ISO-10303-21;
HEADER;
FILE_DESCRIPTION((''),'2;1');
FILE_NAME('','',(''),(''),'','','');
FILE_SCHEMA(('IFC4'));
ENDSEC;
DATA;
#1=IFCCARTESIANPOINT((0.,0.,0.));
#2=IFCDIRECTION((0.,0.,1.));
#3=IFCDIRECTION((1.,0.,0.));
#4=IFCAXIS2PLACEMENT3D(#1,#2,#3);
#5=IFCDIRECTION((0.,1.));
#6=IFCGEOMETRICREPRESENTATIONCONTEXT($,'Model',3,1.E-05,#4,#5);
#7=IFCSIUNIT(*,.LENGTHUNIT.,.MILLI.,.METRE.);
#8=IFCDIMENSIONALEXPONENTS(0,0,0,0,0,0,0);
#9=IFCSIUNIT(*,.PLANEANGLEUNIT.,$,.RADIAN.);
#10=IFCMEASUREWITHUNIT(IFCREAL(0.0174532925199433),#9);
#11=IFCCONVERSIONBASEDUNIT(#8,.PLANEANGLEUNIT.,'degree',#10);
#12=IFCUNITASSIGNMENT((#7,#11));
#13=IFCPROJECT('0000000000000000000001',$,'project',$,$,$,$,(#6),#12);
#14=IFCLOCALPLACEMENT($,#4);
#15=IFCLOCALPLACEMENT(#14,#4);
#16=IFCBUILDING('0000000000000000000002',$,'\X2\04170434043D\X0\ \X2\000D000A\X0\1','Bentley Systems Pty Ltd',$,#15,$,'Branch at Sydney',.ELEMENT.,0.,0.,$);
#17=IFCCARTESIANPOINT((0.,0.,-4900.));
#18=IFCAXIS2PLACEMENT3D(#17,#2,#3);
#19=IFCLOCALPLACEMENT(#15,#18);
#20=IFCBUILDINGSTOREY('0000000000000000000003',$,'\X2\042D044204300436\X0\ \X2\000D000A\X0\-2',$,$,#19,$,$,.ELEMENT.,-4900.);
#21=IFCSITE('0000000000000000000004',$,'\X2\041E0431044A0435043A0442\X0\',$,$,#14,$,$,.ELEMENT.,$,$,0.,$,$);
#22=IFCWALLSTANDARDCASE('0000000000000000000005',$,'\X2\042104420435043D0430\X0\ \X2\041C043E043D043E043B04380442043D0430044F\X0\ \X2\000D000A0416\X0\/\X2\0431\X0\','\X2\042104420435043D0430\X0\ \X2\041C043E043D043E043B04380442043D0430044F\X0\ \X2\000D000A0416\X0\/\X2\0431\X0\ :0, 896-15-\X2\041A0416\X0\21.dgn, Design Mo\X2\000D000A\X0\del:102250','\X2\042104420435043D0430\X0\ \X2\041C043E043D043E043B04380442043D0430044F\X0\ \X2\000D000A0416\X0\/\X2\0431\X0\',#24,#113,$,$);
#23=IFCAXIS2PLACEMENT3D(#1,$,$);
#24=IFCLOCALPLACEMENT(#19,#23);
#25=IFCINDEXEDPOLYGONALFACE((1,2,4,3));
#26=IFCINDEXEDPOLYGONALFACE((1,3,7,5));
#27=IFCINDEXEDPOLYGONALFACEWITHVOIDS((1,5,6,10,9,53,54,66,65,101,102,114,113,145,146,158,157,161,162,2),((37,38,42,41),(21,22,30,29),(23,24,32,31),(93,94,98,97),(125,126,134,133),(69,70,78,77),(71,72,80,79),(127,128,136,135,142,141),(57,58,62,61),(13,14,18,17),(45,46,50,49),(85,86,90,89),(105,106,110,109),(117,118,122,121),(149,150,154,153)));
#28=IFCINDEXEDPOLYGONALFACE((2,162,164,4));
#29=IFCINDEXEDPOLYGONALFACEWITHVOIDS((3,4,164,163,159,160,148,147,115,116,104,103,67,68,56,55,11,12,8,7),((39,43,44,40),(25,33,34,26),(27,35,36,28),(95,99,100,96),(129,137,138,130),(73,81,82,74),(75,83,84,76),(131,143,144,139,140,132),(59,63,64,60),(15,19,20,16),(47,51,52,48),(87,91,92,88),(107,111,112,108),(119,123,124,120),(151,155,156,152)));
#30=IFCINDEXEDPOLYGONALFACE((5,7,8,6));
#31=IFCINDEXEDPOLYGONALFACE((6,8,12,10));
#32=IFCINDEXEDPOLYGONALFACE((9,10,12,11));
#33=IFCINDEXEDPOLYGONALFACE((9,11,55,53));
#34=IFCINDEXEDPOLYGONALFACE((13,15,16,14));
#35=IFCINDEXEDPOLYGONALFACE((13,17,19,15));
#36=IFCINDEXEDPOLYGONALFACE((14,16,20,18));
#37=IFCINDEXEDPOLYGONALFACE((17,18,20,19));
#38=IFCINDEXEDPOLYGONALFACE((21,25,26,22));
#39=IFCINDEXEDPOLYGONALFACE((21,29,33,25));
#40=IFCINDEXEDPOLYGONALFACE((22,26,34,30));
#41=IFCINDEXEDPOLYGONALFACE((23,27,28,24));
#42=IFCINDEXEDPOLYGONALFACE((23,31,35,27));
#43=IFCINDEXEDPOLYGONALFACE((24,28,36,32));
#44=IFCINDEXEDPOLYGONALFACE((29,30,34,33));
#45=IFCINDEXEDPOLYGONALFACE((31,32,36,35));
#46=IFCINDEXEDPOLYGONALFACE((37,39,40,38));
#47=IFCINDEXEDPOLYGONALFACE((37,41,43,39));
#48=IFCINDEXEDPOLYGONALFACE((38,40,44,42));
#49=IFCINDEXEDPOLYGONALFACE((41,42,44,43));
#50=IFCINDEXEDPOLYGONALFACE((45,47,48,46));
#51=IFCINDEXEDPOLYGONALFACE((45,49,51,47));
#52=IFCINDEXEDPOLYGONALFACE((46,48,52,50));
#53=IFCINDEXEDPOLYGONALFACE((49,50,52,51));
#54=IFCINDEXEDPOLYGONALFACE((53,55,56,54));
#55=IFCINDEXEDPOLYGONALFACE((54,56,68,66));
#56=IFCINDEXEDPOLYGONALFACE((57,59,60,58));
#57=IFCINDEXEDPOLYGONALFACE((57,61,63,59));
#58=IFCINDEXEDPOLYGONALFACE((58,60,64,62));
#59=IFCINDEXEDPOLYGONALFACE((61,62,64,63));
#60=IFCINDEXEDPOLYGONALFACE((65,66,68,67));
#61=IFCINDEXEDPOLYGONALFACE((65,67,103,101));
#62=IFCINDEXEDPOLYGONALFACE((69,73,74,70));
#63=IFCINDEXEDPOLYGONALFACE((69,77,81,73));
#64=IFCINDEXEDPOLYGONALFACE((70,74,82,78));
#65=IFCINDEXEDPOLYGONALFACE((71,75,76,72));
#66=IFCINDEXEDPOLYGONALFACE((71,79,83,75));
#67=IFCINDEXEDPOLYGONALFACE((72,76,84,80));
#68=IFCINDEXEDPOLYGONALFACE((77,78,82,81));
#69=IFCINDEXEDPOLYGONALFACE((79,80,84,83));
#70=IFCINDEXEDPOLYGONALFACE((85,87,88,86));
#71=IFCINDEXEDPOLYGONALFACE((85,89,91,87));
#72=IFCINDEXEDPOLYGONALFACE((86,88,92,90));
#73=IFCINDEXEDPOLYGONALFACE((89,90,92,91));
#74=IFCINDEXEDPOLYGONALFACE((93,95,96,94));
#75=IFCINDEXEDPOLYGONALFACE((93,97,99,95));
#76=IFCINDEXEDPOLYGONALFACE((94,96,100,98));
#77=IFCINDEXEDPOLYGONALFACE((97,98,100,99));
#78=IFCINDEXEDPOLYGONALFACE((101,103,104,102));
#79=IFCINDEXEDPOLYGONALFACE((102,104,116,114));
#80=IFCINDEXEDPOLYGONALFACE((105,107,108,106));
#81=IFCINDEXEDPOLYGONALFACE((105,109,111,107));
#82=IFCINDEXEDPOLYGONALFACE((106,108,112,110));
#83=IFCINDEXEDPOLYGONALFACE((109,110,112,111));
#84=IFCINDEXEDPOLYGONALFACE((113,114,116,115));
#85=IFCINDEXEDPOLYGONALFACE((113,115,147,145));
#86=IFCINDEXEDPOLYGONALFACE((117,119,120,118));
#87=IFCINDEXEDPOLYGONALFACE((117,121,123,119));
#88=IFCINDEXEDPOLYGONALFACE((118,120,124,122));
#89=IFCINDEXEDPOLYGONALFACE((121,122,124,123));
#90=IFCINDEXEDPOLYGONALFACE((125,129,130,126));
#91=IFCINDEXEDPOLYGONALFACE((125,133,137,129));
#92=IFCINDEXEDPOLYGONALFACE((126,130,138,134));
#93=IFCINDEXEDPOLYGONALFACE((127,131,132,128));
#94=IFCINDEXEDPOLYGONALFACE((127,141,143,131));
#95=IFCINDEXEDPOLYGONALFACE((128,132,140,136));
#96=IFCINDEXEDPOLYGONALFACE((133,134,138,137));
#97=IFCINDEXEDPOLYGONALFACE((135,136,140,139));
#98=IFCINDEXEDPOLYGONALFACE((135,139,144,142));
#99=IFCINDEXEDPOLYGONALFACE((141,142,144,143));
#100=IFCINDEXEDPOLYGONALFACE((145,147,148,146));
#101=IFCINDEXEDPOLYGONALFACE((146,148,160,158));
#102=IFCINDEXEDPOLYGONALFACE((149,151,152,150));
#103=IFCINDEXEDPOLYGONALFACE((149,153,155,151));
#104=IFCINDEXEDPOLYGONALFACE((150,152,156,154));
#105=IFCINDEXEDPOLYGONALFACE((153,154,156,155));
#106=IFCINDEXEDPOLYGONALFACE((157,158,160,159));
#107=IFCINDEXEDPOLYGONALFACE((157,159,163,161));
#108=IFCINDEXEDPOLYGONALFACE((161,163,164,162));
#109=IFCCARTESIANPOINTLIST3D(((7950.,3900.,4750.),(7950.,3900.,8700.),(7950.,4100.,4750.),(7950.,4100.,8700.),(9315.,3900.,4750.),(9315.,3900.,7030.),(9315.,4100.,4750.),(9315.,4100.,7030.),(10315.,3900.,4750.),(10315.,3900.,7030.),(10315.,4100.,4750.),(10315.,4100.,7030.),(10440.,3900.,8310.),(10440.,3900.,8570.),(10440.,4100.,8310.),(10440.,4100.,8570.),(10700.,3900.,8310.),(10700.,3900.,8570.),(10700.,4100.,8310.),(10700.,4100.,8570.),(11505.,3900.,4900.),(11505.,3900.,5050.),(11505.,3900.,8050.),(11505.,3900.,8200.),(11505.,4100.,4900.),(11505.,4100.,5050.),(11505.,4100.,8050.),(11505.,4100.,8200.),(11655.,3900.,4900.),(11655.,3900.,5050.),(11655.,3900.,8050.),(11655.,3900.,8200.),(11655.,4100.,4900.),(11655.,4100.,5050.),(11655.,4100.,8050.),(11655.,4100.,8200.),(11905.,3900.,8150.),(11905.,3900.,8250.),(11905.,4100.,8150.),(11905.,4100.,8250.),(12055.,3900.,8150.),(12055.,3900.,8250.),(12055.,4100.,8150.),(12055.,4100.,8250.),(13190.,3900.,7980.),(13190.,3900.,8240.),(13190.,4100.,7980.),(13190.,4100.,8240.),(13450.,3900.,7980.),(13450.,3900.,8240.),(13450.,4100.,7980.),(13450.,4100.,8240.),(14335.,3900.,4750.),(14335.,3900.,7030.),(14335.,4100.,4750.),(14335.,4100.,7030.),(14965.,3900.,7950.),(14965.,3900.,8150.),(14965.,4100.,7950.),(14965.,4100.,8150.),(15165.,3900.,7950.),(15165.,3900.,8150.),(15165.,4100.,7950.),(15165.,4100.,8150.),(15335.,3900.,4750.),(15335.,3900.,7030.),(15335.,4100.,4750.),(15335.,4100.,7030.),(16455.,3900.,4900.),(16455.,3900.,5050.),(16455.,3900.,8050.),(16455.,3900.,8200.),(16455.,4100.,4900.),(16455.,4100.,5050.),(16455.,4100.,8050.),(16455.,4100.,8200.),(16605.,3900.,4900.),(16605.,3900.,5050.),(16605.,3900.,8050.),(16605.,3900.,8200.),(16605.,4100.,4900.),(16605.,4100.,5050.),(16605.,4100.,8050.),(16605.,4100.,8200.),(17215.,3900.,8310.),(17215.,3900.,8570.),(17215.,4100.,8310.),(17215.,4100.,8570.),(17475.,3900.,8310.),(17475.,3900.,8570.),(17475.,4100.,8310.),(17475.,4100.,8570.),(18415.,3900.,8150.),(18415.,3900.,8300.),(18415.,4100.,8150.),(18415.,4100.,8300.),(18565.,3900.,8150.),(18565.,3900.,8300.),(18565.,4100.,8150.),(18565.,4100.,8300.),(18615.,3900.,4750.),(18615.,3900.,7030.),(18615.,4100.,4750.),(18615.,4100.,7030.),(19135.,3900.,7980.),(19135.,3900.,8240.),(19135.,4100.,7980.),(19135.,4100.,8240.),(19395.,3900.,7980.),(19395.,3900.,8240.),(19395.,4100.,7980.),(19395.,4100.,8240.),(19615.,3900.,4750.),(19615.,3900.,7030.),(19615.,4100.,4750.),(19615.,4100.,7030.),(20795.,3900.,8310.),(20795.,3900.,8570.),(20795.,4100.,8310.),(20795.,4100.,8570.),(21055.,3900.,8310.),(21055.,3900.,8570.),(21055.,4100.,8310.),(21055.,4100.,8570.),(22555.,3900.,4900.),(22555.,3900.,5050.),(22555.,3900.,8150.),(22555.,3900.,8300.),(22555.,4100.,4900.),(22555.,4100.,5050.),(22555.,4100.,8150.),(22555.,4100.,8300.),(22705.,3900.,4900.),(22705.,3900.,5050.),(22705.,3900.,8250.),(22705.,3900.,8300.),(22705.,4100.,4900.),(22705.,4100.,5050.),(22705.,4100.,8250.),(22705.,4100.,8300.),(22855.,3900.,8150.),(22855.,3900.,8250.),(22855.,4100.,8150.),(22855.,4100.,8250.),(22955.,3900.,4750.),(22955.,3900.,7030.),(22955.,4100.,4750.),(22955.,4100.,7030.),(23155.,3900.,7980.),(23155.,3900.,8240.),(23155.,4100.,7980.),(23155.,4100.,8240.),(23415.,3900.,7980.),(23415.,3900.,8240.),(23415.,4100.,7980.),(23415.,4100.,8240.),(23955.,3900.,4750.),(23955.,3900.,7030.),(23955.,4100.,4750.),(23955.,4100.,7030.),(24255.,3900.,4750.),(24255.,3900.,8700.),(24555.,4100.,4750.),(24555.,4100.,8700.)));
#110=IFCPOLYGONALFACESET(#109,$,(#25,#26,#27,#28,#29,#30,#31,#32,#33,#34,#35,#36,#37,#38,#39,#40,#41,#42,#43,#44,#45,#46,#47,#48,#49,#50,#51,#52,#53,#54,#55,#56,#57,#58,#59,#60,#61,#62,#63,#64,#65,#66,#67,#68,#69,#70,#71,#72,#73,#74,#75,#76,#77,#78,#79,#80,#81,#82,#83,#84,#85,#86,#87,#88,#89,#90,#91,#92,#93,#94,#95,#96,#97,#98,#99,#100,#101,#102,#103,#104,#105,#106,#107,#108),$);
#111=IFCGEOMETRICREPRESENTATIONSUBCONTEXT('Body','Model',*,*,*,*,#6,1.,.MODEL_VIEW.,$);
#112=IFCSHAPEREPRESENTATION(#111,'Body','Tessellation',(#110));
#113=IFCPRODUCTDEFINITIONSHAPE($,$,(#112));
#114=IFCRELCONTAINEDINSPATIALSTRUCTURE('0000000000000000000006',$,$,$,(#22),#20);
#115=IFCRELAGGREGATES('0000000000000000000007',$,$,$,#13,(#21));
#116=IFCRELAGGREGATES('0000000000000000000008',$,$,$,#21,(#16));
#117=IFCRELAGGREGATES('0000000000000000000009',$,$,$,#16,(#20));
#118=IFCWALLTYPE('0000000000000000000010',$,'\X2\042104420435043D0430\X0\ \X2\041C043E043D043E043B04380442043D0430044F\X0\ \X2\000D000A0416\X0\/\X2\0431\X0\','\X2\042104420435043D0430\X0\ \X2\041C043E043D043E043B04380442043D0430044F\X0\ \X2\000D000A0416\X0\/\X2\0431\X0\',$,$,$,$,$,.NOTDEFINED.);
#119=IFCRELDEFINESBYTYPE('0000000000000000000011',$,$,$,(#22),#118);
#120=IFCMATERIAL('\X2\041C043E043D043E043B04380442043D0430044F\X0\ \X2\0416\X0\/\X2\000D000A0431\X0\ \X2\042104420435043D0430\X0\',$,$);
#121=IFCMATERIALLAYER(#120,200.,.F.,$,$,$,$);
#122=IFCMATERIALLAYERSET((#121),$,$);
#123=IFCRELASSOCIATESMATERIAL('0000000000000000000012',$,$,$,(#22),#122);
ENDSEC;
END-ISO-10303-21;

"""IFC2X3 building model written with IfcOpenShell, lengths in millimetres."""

from ifc_helpers import new_model, entity, si_unit, converted_unit, direction, frame, frame_2d, origin_with_axes, place, context, subcontext, project, spatial, polyline, rectangle, outline, extrude, material, layer, layer_set, layer_usage, type_object, element, save


model = new_model("IFC2X3")

# Units and contexts
model_context = context("Model", 3, precision=1e-05, world=origin_with_axes(), true_north=direction((0.0, 1.0)))
body_context = subcontext(model_context, "Body", "Model", "MODEL_VIEW", scale=1.0)
ifc_project = project(units=[si_unit("LENGTHUNIT", "METRE", prefix="MILLI"), converted_unit("PLANEANGLEUNIT", "degree", entity("IfcReal", 0.0174532925199433), si_unit("PLANEANGLEUNIT", "RADIAN"), dimensions=[0, 0, 0, 0, 0, 0, 0])], contexts=[model_context])

# Site, building, storey
site_placement = place(None, origin_with_axes())
site = spatial("IfcSite", under=ifc_project, at=site_placement, Name="Объект", CompositionType="ELEMENT", RefElevation=0.0)
building_placement = place(site_placement, origin_with_axes())
building = spatial("IfcBuilding", under=site, at=building_placement, Name="Здн \r\n1", Description="Bentley Systems Pty Ltd", LongName="Branch at Sydney", CompositionType="ELEMENT", ElevationOfRefHeight=0.0, ElevationOfTerrain=0.0)
storey_placement = place(building_placement, frame((0.0, 0.0, -4900.0), z_axis=(0.0, 0.0, 1.0), x_axis=(1.0, 0.0, 0.0)))
storey = spatial("IfcBuildingStorey", under=building, at=storey_placement, Name="Этаж \r\n-2", CompositionType="ELEMENT", Elevation=-4900.0)

# Wall, openings
ifc_material = material(Name="Монолитная Ж/\r\nб Стена")
wall_type = type_object("IfcWallType", Name="Стена Монолитная \r\nЖ/б", Description="Стена Монолитная \r\nЖ/б", PredefinedType="NOTDEFINED")
ifc_layer_1 = layer(ifc_material, 200.0, ventilated=False)
ifc_layer_set_1 = layer_set([ifc_layer_1])
ifc_layer_usage_1 = layer_usage(ifc_layer_set_1, "AXIS2", "POSITIVE", 0.0)
wall_1_placement = place(storey_placement, frame((7950.0, 3900.0, 4750.0), z_axis=(0.0, 0.0, 1.0), x_axis=(1.0, 0.0, 0.0)))
wall_1 = element("IfcWallStandardCase", 1, at=wall_1_placement, inside=storey, type_object=wall_type, material=ifc_layer_usage_1, Name="Стена Монолитная \r\nЖ/б", Description="Стена Монолитная \r\nЖ/б :0, 896-15-КЖ21.dgn, Design Mo\r\ndel:102250", ObjectType="Стена Монолитная \r\nЖ/б", context=body_context, shape_type="SweptSolid", body=[
    extrude(outline(polyline([(16605.0, 200.0), (0.0, 200.0), (0.0, 0.0), (16305.0, 0.0), (16605.0, 200.0)])), origin_with_axes(), (0.0, 0.0, 1.0), 3950.0),
])
opening_1_placement = place(wall_1_placement, frame((1365.0, 0.0, 0.0), z_axis=(0.0, 0.0, 1.0), x_axis=(1.0, 0.0, 0.0)))
element("IfcOpeningElement", 2, at=opening_1_placement, cuts=wall_1, ObjectType="Opening", context=body_context, shape_type="SweptSolid", body=[
    extrude(rectangle(XDim=2280.0, YDim=1000.0, at=frame_2d((-500.0, 1140.0), x_axis=(0.0, -1.0))), frame((0.0, 0.0, 0.0), z_axis=(0.0, 1.0, 0.0), x_axis=(-1.0, 0.0, 0.0)), (0.0, 0.0, 1.0), 200.0),
])
opening_2_placement = place(wall_1_placement, frame((6385.0, 0.0, 0.0), z_axis=(0.0, 0.0, 1.0), x_axis=(1.0, 0.0, 0.0)))
element("IfcOpeningElement", 3, at=opening_2_placement, cuts=wall_1, ObjectType="Opening", context=body_context, shape_type="SweptSolid", body=[
    extrude(rectangle(XDim=2280.0, YDim=1000.0, at=frame_2d((-500.0, 1140.0), x_axis=(0.0, -1.0))), frame((0.0, 0.0, 0.0), z_axis=(0.0, 1.0, 0.0), x_axis=(-1.0, 0.0, 0.0)), (0.0, 0.0, 1.0), 200.0),
])
opening_3_placement = place(wall_1_placement, frame((10665.0, 0.0, 0.0), z_axis=(0.0, 0.0, 1.0), x_axis=(1.0, 0.0, 0.0)))
element("IfcOpeningElement", 4, at=opening_3_placement, cuts=wall_1, ObjectType="Opening", context=body_context, shape_type="SweptSolid", body=[
    extrude(rectangle(XDim=2280.0, YDim=1000.0, at=frame_2d((-500.0, 1140.0), x_axis=(0.0, -1.0))), frame((0.0, 0.0, 0.0), z_axis=(0.0, 1.0, 0.0), x_axis=(-1.0, 0.0, 0.0)), (0.0, 0.0, 1.0), 200.0),
])
opening_4_placement = place(wall_1_placement, frame((15005.0, 0.0, 0.0), z_axis=(0.0, 0.0, 1.0), x_axis=(1.0, 0.0, 0.0)))
element("IfcOpeningElement", 5, at=opening_4_placement, cuts=wall_1, ObjectType="Opening", context=body_context, shape_type="SweptSolid", body=[
    extrude(rectangle(XDim=2280.0, YDim=1000.0, at=frame_2d((-500.0, 1140.0), x_axis=(0.0, -1.0))), frame((0.0, 0.0, 0.0), z_axis=(0.0, 1.0, 0.0), x_axis=(-1.0, 0.0, 0.0)), (0.0, 0.0, 1.0), 200.0),
])
opening_5_placement = place(wall_1_placement, frame((7015.0, 0.0, 3200.0), z_axis=(0.0, 0.0, 1.0), x_axis=(1.0, 0.0, 0.0)))
element("IfcOpeningElement", 6, at=opening_5_placement, cuts=wall_1, ObjectType="Opening", context=body_context, shape_type="SweptSolid", body=[
    extrude(rectangle(XDim=200.0, YDim=200.0, at=frame_2d((-100.0, 100.0), x_axis=(0.0, -1.0))), frame((0.0, 0.0, 0.0), z_axis=(0.0, 1.0, 0.0), x_axis=(-1.0, 0.0, 0.0)), (0.0, 0.0, 1.0), 200.0),
])
opening_6_placement = place(wall_1_placement, frame((8505.0, 0.0, 150.0), z_axis=(0.0, 0.0, 1.0), x_axis=(1.0, 0.0, 0.0)))
element("IfcOpeningElement", 7, at=opening_6_placement, cuts=wall_1, ObjectType="Opening", context=body_context, shape_type="SweptSolid", body=[
    extrude(rectangle(XDim=150.0, YDim=150.0, at=frame_2d((-75.0, 75.0), x_axis=(0.0, -1.0))), frame((0.0, 0.0, 0.0), z_axis=(0.0, 1.0, 0.0), x_axis=(-1.0, 0.0, 0.0)), (0.0, 0.0, 1.0), 200.0),
])
opening_7_placement = place(wall_1_placement, frame((8505.0, 0.0, 3300.0), z_axis=(0.0, 0.0, 1.0), x_axis=(1.0, 0.0, 0.0)))
element("IfcOpeningElement", 8, at=opening_7_placement, cuts=wall_1, ObjectType="Opening", context=body_context, shape_type="SweptSolid", body=[
    extrude(rectangle(XDim=150.0, YDim=150.0, at=frame_2d((-75.0, 75.0), x_axis=(0.0, -1.0))), frame((0.0, 0.0, 0.0), z_axis=(0.0, 1.0, 0.0), x_axis=(-1.0, 0.0, 0.0)), (0.0, 0.0, 1.0), 200.0),
])
opening_8_placement = place(wall_1_placement, frame((9265.0, 0.0, 3560.0), z_axis=(0.0, 0.0, 1.0), x_axis=(1.0, 0.0, 0.0)))
element("IfcOpeningElement", 9, at=opening_8_placement, cuts=wall_1, ObjectType="Opening", context=body_context, shape_type="SweptSolid", body=[
    extrude(rectangle(XDim=260.0, YDim=260.0, at=frame_2d((-130.0, 130.0), x_axis=(0.0, -1.0))), frame((0.0, 0.0, 0.0), z_axis=(0.0, 1.0, 0.0), x_axis=(-1.0, 0.0, 0.0)), (0.0, 0.0, 1.0), 200.0),
])
opening_9_placement = place(wall_1_placement, frame((10465.0, 0.0, 3400.0), z_axis=(0.0, 0.0, 1.0), x_axis=(1.0, 0.0, 0.0)))
element("IfcOpeningElement", 10, at=opening_9_placement, cuts=wall_1, ObjectType="Opening", context=body_context, shape_type="SweptSolid", body=[
    extrude(rectangle(XDim=150.0, YDim=150.0, at=frame_2d((-75.0, 75.0), x_axis=(0.0, -1.0))), frame((0.0, 0.0, 0.0), z_axis=(0.0, 1.0, 0.0), x_axis=(-1.0, 0.0, 0.0)), (0.0, 0.0, 1.0), 200.0),
])
opening_10_placement = place(wall_1_placement, frame((11185.0, 0.0, 3230.0), z_axis=(0.0, 0.0, 1.0), x_axis=(1.0, 0.0, 0.0)))
element("IfcOpeningElement", 11, at=opening_10_placement, cuts=wall_1, ObjectType="Opening", context=body_context, shape_type="SweptSolid", body=[
    extrude(rectangle(XDim=260.0, YDim=260.0, at=frame_2d((-130.0, 130.0), x_axis=(0.0, -1.0))), frame((0.0, 0.0, 0.0), z_axis=(0.0, 1.0, 0.0), x_axis=(-1.0, 0.0, 0.0)), (0.0, 0.0, 1.0), 200.0),
])
opening_11_placement = place(wall_1_placement, frame((12845.0, 0.0, 3560.0), z_axis=(0.0, 0.0, 1.0), x_axis=(1.0, 0.0, 0.0)))
element("IfcOpeningElement", 12, at=opening_11_placement, cuts=wall_1, ObjectType="Opening", context=body_context, shape_type="SweptSolid", body=[
    extrude(rectangle(XDim=260.0, YDim=260.0, at=frame_2d((-130.0, 130.0), x_axis=(0.0, -1.0))), frame((0.0, 0.0, 0.0), z_axis=(0.0, 1.0, 0.0), x_axis=(-1.0, 0.0, 0.0)), (0.0, 0.0, 1.0), 200.0),
])
opening_12_placement = place(wall_1_placement, frame((15205.0, 0.0, 3230.0), z_axis=(0.0, 0.0, 1.0), x_axis=(1.0, 0.0, 0.0)))
element("IfcOpeningElement", 13, at=opening_12_placement, cuts=wall_1, ObjectType="Opening", context=body_context, shape_type="SweptSolid", body=[
    extrude(rectangle(XDim=260.0, YDim=260.0, at=frame_2d((-130.0, 130.0), x_axis=(0.0, -1.0))), frame((0.0, 0.0, 0.0), z_axis=(0.0, 1.0, 0.0), x_axis=(-1.0, 0.0, 0.0)), (0.0, 0.0, 1.0), 200.0),
])
opening_13_placement = place(wall_1_placement, frame((14605.0, 0.0, 150.0), z_axis=(0.0, 0.0, 1.0), x_axis=(1.0, 0.0, 0.0)))
element("IfcOpeningElement", 14, at=opening_13_placement, cuts=wall_1, ObjectType="Opening", context=body_context, shape_type="SweptSolid", body=[
    extrude(rectangle(XDim=150.0, YDim=150.0, at=frame_2d((-75.0, 75.0), x_axis=(0.0, -1.0))), frame((0.0, 0.0, 0.0), z_axis=(0.0, 1.0, 0.0), x_axis=(-1.0, 0.0, 0.0)), (0.0, 0.0, 1.0), 200.0),
])
opening_14_placement = place(wall_1_placement, frame((14605.0, 0.0, 3400.0), z_axis=(0.0, 0.0, 1.0), x_axis=(1.0, 0.0, 0.0)))
element("IfcOpeningElement", 15, at=opening_14_placement, cuts=wall_1, ObjectType="Opening", context=body_context, shape_type="SweptSolid", body=[
    extrude(outline(polyline([(-150.0, 150.0), (0.0, 150.0), (0.0, 0.0), (-300.0, 0.0), (-300.0, 100.0), (-150.0, 100.0), (-150.0, 150.0)])), frame((0.0, 0.0, 0.0), z_axis=(0.0, 1.0, 0.0), x_axis=(-1.0, 0.0, 0.0)), (0.0, 0.0, 1.0), 200.0),
])
opening_15_placement = place(wall_1_placement, frame((2490.0, 0.0, 3560.0), z_axis=(0.0, 0.0, 1.0), x_axis=(1.0, 0.0, 0.0)))
element("IfcOpeningElement", 16, at=opening_15_placement, cuts=wall_1, ObjectType="Opening", context=body_context, shape_type="SweptSolid", body=[
    extrude(rectangle(XDim=260.0, YDim=260.0, at=frame_2d((-130.0, 130.0), x_axis=(0.0, -1.0))), frame((0.0, 0.0, 0.0), z_axis=(0.0, 1.0, 0.0), x_axis=(-1.0, 0.0, 0.0)), (0.0, 0.0, 1.0), 200.0),
])
opening_16_placement = place(wall_1_placement, frame((3555.0, 0.0, 3300.0), z_axis=(0.0, 0.0, 1.0), x_axis=(1.0, 0.0, 0.0)))
element("IfcOpeningElement", 17, at=opening_16_placement, cuts=wall_1, ObjectType="Opening", context=body_context, shape_type="SweptSolid", body=[
    extrude(rectangle(XDim=150.0, YDim=150.0, at=frame_2d((-75.0, 75.0), x_axis=(0.0, -1.0))), frame((0.0, 0.0, 0.0), z_axis=(0.0, 1.0, 0.0), x_axis=(-1.0, 0.0, 0.0)), (0.0, 0.0, 1.0), 200.0),
])
opening_17_placement = place(wall_1_placement, frame((3955.0, 0.0, 3400.0), z_axis=(0.0, 0.0, 1.0), x_axis=(1.0, 0.0, 0.0)))
element("IfcOpeningElement", 18, at=opening_17_placement, cuts=wall_1, ObjectType="Opening", context=body_context, shape_type="SweptSolid", body=[
    extrude(rectangle(XDim=100.0, YDim=150.0, at=frame_2d((-75.0, 50.0), x_axis=(0.0, -1.0))), frame((0.0, 0.0, 0.0), z_axis=(0.0, 1.0, 0.0), x_axis=(-1.0, 0.0, 0.0)), (0.0, 0.0, 1.0), 200.0),
])
opening_18_placement = place(wall_1_placement, frame((3555.0, 0.0, 150.0), z_axis=(0.0, 0.0, 1.0), x_axis=(1.0, 0.0, 0.0)))
element("IfcOpeningElement", 19, at=opening_18_placement, cuts=wall_1, ObjectType="Opening", context=body_context, shape_type="SweptSolid", body=[
    extrude(rectangle(XDim=150.0, YDim=150.0, at=frame_2d((-75.0, 75.0), x_axis=(0.0, -1.0))), frame((0.0, 0.0, 0.0), z_axis=(0.0, 1.0, 0.0), x_axis=(-1.0, 0.0, 0.0)), (0.0, 0.0, 1.0), 200.0),
])
opening_19_placement = place(wall_1_placement, frame((5240.0, 0.0, 3230.0), z_axis=(0.0, 0.0, 1.0), x_axis=(1.0, 0.0, 0.0)))
element("IfcOpeningElement", 20, at=opening_19_placement, cuts=wall_1, ObjectType="Opening", context=body_context, shape_type="SweptSolid", body=[
    extrude(rectangle(XDim=260.0, YDim=260.0, at=frame_2d((-130.0, 130.0), x_axis=(0.0, -1.0))), frame((0.0, 0.0, 0.0), z_axis=(0.0, 1.0, 0.0), x_axis=(-1.0, 0.0, 0.0)), (0.0, 0.0, 1.0), 200.0),
])

save(model, "model.ifc")
